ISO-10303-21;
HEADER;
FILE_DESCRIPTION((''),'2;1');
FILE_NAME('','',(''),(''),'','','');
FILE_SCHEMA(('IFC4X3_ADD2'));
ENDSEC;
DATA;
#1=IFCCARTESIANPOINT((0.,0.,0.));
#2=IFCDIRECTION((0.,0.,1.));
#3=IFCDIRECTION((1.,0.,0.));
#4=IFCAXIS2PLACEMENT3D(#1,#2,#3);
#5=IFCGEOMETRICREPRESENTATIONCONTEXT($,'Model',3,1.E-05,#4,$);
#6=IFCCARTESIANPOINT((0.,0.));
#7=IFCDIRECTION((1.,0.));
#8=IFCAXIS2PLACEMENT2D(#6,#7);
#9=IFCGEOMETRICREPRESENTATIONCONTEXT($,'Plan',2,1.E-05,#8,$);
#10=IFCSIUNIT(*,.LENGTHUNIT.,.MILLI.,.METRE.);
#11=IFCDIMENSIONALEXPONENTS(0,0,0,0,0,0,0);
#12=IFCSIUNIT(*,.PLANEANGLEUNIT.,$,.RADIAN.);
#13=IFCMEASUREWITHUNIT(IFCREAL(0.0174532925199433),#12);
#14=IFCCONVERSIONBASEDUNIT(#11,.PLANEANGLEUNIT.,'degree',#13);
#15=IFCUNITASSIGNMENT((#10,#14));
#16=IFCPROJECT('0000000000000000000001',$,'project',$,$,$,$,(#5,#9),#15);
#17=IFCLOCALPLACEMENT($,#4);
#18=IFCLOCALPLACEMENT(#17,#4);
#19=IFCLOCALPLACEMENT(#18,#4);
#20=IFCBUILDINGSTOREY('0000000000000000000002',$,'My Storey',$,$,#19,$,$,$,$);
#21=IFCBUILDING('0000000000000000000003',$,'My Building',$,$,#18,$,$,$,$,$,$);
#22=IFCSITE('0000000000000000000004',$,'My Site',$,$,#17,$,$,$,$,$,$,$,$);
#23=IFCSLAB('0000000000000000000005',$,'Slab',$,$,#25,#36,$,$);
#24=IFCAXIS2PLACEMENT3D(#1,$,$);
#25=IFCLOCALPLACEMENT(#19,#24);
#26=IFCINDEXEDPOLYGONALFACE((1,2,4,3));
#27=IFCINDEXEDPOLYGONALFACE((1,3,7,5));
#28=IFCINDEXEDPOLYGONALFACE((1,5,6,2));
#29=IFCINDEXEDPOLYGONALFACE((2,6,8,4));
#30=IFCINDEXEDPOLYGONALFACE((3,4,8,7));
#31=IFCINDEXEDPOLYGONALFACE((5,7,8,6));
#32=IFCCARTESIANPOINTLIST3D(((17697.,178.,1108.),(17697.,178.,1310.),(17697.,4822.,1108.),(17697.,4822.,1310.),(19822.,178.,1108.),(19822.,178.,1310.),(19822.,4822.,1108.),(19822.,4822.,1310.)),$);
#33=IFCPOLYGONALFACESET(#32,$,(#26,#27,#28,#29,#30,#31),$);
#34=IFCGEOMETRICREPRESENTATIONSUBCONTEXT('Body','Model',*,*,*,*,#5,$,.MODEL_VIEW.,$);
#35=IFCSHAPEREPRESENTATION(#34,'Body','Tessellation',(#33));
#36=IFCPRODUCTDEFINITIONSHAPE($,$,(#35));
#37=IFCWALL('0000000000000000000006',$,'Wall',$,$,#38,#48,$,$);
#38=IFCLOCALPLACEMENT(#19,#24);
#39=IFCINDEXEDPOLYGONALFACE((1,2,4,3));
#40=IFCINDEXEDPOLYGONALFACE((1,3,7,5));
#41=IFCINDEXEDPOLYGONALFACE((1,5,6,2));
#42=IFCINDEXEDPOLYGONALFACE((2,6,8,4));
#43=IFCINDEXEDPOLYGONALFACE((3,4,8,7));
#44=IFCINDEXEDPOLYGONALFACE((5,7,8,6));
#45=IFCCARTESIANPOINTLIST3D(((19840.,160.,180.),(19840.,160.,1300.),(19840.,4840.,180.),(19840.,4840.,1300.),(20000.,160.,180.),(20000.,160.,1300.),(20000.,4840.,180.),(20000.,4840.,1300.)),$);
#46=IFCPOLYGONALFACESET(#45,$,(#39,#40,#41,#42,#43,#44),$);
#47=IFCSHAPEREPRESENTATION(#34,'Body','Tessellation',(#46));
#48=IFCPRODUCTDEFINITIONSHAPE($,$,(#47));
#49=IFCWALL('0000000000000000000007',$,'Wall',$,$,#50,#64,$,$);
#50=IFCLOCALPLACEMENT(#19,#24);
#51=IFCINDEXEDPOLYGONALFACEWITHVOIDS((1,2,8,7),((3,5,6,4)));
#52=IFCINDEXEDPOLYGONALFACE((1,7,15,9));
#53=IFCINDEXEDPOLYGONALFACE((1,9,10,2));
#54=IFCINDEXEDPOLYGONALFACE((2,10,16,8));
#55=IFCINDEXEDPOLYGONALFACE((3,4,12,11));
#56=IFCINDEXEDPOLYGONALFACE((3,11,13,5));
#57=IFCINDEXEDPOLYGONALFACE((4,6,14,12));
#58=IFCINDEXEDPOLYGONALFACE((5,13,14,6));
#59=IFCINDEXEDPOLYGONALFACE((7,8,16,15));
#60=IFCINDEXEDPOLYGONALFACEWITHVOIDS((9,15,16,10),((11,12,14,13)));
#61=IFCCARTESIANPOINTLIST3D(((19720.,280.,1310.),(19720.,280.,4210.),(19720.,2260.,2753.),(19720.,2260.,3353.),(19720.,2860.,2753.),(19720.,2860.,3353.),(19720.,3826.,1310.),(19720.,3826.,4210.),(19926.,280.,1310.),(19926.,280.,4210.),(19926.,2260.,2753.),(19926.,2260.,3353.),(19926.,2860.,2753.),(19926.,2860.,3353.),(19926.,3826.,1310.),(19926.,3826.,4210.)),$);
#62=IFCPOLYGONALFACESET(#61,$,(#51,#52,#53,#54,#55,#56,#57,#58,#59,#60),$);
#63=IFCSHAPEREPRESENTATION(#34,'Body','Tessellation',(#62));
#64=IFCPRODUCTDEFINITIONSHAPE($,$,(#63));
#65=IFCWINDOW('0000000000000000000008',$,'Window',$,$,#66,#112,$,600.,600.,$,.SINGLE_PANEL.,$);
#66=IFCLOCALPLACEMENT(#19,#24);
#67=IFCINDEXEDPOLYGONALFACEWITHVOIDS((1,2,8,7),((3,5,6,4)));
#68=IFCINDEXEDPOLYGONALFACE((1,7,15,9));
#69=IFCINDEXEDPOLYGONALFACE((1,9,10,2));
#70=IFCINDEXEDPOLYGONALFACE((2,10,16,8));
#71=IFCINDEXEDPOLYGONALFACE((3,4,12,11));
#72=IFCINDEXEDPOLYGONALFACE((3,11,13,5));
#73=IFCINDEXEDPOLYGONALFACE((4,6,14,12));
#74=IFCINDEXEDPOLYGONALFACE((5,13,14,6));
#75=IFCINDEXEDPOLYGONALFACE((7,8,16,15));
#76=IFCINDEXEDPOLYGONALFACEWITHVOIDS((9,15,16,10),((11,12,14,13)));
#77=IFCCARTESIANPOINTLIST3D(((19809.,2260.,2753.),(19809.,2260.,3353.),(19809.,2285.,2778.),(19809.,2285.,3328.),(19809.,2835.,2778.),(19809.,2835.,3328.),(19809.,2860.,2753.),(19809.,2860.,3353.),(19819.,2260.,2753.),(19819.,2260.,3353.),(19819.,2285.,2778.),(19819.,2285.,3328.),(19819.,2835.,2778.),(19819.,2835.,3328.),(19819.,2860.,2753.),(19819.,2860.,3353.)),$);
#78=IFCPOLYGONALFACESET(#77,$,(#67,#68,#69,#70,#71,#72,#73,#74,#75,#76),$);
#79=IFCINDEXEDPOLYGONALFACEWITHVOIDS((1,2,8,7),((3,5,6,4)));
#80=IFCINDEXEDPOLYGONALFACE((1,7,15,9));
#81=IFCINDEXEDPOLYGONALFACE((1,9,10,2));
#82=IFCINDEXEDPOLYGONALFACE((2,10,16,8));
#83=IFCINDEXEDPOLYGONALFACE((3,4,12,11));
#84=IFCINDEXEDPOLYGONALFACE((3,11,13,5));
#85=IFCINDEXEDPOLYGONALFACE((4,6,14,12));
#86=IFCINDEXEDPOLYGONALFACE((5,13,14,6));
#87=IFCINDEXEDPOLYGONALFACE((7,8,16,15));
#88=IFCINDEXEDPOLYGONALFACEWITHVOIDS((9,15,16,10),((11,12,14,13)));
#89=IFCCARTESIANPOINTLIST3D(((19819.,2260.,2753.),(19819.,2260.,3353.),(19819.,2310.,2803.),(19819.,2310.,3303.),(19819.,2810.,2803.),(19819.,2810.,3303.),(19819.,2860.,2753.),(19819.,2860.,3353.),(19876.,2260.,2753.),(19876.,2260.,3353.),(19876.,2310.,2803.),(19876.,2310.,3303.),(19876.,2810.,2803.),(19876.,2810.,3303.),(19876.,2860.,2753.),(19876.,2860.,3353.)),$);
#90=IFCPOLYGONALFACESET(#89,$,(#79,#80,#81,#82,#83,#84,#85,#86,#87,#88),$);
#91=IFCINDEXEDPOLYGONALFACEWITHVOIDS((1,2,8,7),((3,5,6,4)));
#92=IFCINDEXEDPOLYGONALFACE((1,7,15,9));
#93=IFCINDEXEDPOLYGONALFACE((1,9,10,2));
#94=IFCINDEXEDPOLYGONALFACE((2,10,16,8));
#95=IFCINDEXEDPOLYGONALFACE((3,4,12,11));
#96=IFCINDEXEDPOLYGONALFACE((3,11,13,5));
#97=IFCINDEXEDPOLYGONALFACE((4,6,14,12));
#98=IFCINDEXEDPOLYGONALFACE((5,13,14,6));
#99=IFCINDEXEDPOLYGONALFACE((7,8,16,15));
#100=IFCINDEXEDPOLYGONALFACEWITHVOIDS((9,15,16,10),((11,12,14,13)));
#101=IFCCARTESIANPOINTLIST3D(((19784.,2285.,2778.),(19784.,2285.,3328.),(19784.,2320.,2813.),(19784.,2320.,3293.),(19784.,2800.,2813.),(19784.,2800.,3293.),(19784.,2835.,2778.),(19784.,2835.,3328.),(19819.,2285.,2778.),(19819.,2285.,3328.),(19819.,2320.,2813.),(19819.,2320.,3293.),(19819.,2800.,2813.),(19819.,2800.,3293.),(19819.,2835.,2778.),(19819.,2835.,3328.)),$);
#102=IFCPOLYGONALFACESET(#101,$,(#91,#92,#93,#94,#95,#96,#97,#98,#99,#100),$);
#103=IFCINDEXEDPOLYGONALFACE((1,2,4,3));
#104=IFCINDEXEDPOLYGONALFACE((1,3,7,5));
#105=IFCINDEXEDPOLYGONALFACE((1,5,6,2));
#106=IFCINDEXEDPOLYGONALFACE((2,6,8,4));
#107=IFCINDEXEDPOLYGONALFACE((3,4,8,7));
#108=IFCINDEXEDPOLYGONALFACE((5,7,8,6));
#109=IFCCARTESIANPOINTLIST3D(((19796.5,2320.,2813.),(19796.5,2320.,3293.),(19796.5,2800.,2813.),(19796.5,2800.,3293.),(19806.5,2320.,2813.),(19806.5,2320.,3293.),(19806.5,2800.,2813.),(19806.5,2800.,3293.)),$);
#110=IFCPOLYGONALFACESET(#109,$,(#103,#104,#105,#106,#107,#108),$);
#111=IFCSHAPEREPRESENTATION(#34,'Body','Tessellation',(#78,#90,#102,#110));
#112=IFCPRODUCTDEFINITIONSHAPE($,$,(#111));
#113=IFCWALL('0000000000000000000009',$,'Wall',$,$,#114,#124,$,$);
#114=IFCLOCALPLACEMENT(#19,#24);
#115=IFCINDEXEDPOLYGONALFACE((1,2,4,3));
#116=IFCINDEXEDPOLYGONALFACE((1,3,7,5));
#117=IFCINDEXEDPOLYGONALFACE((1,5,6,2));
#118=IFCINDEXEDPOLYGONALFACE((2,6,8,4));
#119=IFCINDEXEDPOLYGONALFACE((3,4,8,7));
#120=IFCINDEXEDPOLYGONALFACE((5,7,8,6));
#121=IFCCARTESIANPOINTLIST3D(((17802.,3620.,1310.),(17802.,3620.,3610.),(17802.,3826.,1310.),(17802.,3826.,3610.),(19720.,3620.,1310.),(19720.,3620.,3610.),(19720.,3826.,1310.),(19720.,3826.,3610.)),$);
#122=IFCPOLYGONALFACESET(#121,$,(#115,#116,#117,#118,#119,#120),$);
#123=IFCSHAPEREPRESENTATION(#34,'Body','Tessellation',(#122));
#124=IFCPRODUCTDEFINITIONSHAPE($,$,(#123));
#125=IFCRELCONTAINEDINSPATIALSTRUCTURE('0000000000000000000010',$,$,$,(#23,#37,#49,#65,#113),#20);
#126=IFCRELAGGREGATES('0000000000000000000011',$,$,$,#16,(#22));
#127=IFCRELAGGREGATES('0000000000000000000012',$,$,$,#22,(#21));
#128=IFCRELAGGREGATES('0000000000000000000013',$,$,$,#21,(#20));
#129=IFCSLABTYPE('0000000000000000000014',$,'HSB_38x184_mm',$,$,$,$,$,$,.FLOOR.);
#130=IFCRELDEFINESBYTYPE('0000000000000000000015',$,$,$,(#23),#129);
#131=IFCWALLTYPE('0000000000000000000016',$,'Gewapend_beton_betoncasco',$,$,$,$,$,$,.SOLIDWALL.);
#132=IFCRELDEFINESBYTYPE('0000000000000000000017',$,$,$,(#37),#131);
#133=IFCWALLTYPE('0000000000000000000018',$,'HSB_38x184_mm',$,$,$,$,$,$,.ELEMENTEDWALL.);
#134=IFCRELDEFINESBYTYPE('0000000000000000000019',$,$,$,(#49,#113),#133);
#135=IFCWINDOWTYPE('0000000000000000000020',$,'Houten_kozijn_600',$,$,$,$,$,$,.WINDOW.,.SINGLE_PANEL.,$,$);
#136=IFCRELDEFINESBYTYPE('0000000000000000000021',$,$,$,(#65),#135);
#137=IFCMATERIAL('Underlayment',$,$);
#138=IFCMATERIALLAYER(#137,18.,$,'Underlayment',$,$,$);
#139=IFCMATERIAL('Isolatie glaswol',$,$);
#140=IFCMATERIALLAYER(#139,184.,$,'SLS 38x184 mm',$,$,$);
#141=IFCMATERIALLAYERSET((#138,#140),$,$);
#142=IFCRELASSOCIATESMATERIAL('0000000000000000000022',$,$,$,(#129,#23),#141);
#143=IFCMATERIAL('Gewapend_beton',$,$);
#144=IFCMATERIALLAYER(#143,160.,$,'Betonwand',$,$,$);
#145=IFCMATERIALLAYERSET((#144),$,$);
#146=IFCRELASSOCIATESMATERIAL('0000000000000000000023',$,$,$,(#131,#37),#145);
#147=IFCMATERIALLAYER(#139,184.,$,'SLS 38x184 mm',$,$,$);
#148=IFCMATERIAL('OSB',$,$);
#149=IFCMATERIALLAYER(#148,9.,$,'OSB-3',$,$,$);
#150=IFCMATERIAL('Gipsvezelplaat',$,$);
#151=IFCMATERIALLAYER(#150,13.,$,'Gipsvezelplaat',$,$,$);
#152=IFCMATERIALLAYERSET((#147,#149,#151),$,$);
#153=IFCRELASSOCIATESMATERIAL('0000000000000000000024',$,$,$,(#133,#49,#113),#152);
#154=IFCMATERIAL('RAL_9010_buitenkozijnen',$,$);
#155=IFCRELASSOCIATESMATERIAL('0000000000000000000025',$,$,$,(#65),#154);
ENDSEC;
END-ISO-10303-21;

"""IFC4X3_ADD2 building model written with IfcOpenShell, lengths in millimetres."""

from ifc_helpers import new_model, entity, si_unit, converted_unit, frame, origin_with_axes, origin_2d_with_axis, place, context, subcontext, project, spatial, line, indexed_curve, outline, extrude, shape, source, transform, mapped, material, layer, layer_set, layer_usage, type_object, type_shapes, element, fill, save


model = new_model("IFC4X3_ADD2")

# Units and contexts
model_context = context("Model", 3, precision=1e-05, world=origin_with_axes())
plan_context = context("Plan", 2, precision=1e-05, world=origin_2d_with_axis())
body_context_1 = subcontext(model_context, "Body", "Model", "MODEL_VIEW")
body_context_2 = subcontext(plan_context, "Body", "Plan", "PLAN_VIEW")
ifc_project = project(units=[si_unit("LENGTHUNIT", "METRE", prefix="MILLI"), converted_unit("PLANEANGLEUNIT", "degree", entity("IfcReal", 0.0174532925199433), si_unit("PLANEANGLEUNIT", "RADIAN"), dimensions=[0, 0, 0, 0, 0, 0, 0])], contexts=[model_context, plan_context])

# Site, building, storey
site_placement = place(None, origin_with_axes())
site = spatial("IfcSite", under=ifc_project, at=site_placement, Name="My Site")
building_placement = place(site_placement, origin_with_axes())
building = spatial("IfcBuilding", under=site, at=building_placement, Name="My Building")
storey_placement = place(building_placement, origin_with_axes())
storey = spatial("IfcBuildingStorey", under=building, at=storey_placement, Name="My Storey")

# Slab
ifc_material_1 = material(Name="Underlayment")
ifc_layer_1 = layer(ifc_material_1, 18.0, Name="Underlayment")
ifc_material_2 = material(Name="Isolatie glaswol")
ifc_layer_2 = layer(ifc_material_2, 184.0, Name="SLS 38x184 mm")
ifc_layer_set_1 = layer_set([ifc_layer_1, ifc_layer_2])
ifc_layer_usage_1 = layer_usage(ifc_layer_set_1, "AXIS3", "POSITIVE", 0.0)
slab_type = type_object("IfcSlabType", Name="HSB_38x184_mm", PredefinedType="FLOOR", material=ifc_layer_set_1)
slab_placement = place(storey_placement, frame((17697.0, 178.0, 1108.0), z_axis=(0.0, 0.0, 1.0), x_axis=(1.0, 0.0, 0.0)))
element("IfcSlab", 1, at=slab_placement, inside=storey, type_object=slab_type, material=ifc_layer_usage_1, Name="Slab", context=body_context_1, shape_type="SweptSolid", body=[
    extrude(outline(indexed_curve([(0.0, 0.0), (2125.0, 0.0), (2125.0, 4644.0), (0.0, 4644.0)], segments=[line(3, 2), line(2, 1), line(1, 4), line(4, 3)], self_intersect=False)), None, (0.0, 0.0, 1.0), 202.0),
])

# Wall
ifc_material_3 = material(Name="Gewapend_beton")
ifc_layer_3 = layer(ifc_material_3, 160.0, Name="Betonwand")
ifc_layer_set_2 = layer_set([ifc_layer_3])
ifc_layer_usage_2 = layer_usage(ifc_layer_set_2, "AXIS2", "POSITIVE", 0.0)
wall_type_1 = type_object("IfcWallType", Name="Gewapend_beton_betoncasco", PredefinedType="SOLIDWALL", material=ifc_layer_set_2)
wall_1_placement = place(storey_placement, frame((19840.0, 4840.0, 180.0), z_axis=(0.0, 0.0, 1.0), x_axis=(0.0, -1.0, 0.0)))
element("IfcWall", 2, at=wall_1_placement, inside=storey, type_object=wall_type_1, material=ifc_layer_usage_2, Name="Wall", context=body_context_1, shape_type="SweptSolid", body=[
    extrude(outline(indexed_curve([(0.0, 0.0), (0.0, 160.0), (4680.0, 160.0), (4680.0, 0.0), (0.0, 0.0)], self_intersect=False)), origin_with_axes(), (0.0, 0.0, 1.0), 1120.0),
])

# Wall, opening, window
ifc_layer_4 = layer(ifc_material_2, 184.0, Name="SLS 38x184 mm")
ifc_material_4 = material(Name="OSB")
ifc_layer_5 = layer(ifc_material_4, 9.0, Name="OSB-3")
ifc_material_5 = material(Name="Gipsvezelplaat")
ifc_layer_6 = layer(ifc_material_5, 13.0, Name="Gipsvezelplaat")
ifc_layer_set_3 = layer_set([ifc_layer_4, ifc_layer_5, ifc_layer_6])
ifc_layer_usage_3 = layer_usage(ifc_layer_set_3, "AXIS2", "POSITIVE", 0.0)
wall_type_2 = type_object("IfcWallType", Name="HSB_38x184_mm", PredefinedType="ELEMENTEDWALL", material=ifc_layer_set_3)
wall_2_placement = place(storey_placement, frame((19926.0, 280.0, 1310.0), z_axis=(0.0, 0.0, 1.0), x_axis=(0.0, 1.0, 0.0)))
wall_2 = element("IfcWall", 3, at=wall_2_placement, inside=storey, type_object=wall_type_2, material=ifc_layer_usage_3, Name="Wall", context=body_context_1, shape_type="SweptSolid", body=[
    extrude(outline(indexed_curve([(0.0, 0.0), (0.0, 206.0), (3546.0, 206.0), (3546.0, 0.0), (0.0, 0.0)], self_intersect=False)), origin_with_axes(), (0.0, 0.0, 1.0), 2900.0),
])
shared_shape_1 = source(origin_with_axes(), body_context_1, "Body", "SweptSolid", [
    extrude(outline(indexed_curve([(0.0, 0.0), (600.0, 0.0), (600.0, 600.0), (0.0, 600.0)], segments=[line(1, 2, 3, 4, 1)])), frame((0.0, -600.0, 0.0), z_axis=(0.0, -1.0, 0.0), x_axis=(1.0, 0.0, 0.0)), (0.0, 0.0, -1.0), 1200.0),
])
opening_1_placement = place(wall_2_placement, frame((1980.0, 0.0, 1443.0), z_axis=(0.0, 0.0, 1.0), x_axis=(1.0, 0.0, 0.0)))
opening_1 = element("IfcOpeningElement", 4, at=opening_1_placement, cuts=wall_2, PredefinedType="OPENING", context=body_context_1, shape_type="MappedRepresentation", body=[
    mapped(shared_shape_1, transform((0.0, 0.0, 0.0), x_axis=(1.0, 0.0, 0.0), y_axis=(0.0, 1.0, 0.0), z_axis=(0.0, 0.0, 1.0), scale=1.0)),
])
ifc_material_6 = material(Name="RAL_9010_buitenkozijnen")
window_type = type_object("IfcWindowType", Name="Houten_kozijn_600", PartitioningType="SINGLE_PANEL", PredefinedType="WINDOW")
shared_shape_2 = source(origin_with_axes(), body_context_1, "Body", "SweptSolid", [
    extrude(outline(indexed_curve([(0.0, 0.0), (600.0, 0.0), (600.0, 600.0), (0.0, 600.0)], segments=[line(1, 2, 3, 4, 1)]), holes=[indexed_curve([(25.0, 25.0), (575.0, 25.0), (575.0, 575.0), (25.0, 575.0)], segments=[line(1, 2, 3, 4, 1)])]), frame((0.0, 107.0, 0.0), z_axis=(0.0, -1.0, 0.0), x_axis=(1.0, 0.0, 0.0)), (0.0, 0.0, -1.0), 10.0),
    extrude(outline(indexed_curve([(0.0, 0.0), (600.0, 0.0), (600.0, 600.0), (0.0, 600.0)], segments=[line(1, 2, 3, 4, 1)]), holes=[indexed_curve([(50.0, 50.0), (550.0, 50.0), (550.0, 550.0), (50.0, 550.0)], segments=[line(1, 2, 3, 4, 1)])]), frame((0.0, 50.0, 0.0), z_axis=(0.0, -1.0, 0.0), x_axis=(1.0, 0.0, 0.0)), (0.0, 0.0, -1.0), 57.0),
    extrude(outline(indexed_curve([(0.0, 0.0), (550.0, 0.0), (550.0, 550.0), (0.0, 550.0)], segments=[line(1, 2, 3, 4, 1)]), holes=[indexed_curve([(35.0, 35.0), (515.0, 35.0), (515.0, 515.0), (35.0, 515.0)], segments=[line(1, 2, 3, 4, 1)])]), frame((25.0, 107.0, 25.0), z_axis=(0.0, -1.0, 0.0), x_axis=(1.0, 0.0, 0.0)), (0.0, 0.0, -1.0), 35.0),
    extrude(outline(indexed_curve([(35.0, 35.0), (515.0, 35.0), (515.0, 515.0), (35.0, 515.0)], segments=[line(1, 2, 3, 4, 1)])), frame((25.0, 119.5, 25.0), z_axis=(0.0, -1.0, 0.0), x_axis=(1.0, 0.0, 0.0)), (0.0, 0.0, -1.0), 10.0),
])
shared_shape_3 = source(origin_with_axes(), body_context_2, "Body", "Curve2D", [
    entity("IfcIndexedPolyCurve", entity("IfcCartesianPointList2D", [[50.0, 50.0], [550.0, 50.0]])),
    entity("IfcIndexedPolyCurve", entity("IfcCartesianPointList2D", [[0.0, 117.0], [25.0, 117.0], [25.0, 107.0], [50.0, 107.0], [50.0, 50.0], [0.0, 50.0]]), [entity("IfcLineIndex", [1, 2, 3, 4, 5, 6, 1])]),
    entity("IfcIndexedPolyCurve", entity("IfcCartesianPointList2D", [[600.0, 117.0], [575.0, 117.0], [575.0, 107.0], [550.0, 107.0], [550.0, 50.0], [600.0, 50.0]]), [entity("IfcLineIndex", [1, 2, 3, 4, 5, 6, 1])]),
    entity("IfcIndexedPolyCurve", entity("IfcCartesianPointList2D", [[25.0, 107.0], [60.0, 107.0], [60.0, 142.0], [25.0, 142.0]]), [entity("IfcLineIndex", [1, 2, 3, 4, 1])]),
    entity("IfcIndexedPolyCurve", entity("IfcCartesianPointList2D", [[575.0, 107.0], [540.0, 107.0], [540.0, 142.0], [575.0, 142.0]]), [entity("IfcLineIndex", [1, 2, 3, 4, 1])]),
    entity("IfcIndexedPolyCurve", entity("IfcCartesianPointList2D", [[60.0, 107.0], [540.0, 107.0]])),
    entity("IfcIndexedPolyCurve", entity("IfcCartesianPointList2D", [[60.0, 142.0], [540.0, 142.0]])),
    entity("IfcIndexedPolyCurve", entity("IfcCartesianPointList2D", [[60.0, 124.5], [540.0, 124.5]])),
])
type_shapes(window_type, [shared_shape_2, shared_shape_3])
window_placement = place(opening_1_placement, origin_with_axes())
window = element("IfcWindow", 5, at=window_placement, inside=storey, type_object=window_type, material=ifc_material_6, Name="Window", OverallHeight=600.0, OverallWidth=600.0, PartitioningType="SINGLE_PANEL", shapes=[
    shape(body_context_1, "Body", "MappedRepresentation", [mapped(shared_shape_2, transform((0.0, 0.0, 0.0), x_axis=(1.0, 0.0, 0.0), y_axis=(0.0, 1.0, 0.0), z_axis=(0.0, 0.0, 1.0), scale=1.0))]),
    shape(body_context_2, "Body", "MappedRepresentation", [mapped(shared_shape_3, transform((0.0, 0.0, 0.0), x_axis=(1.0, 0.0, 0.0), y_axis=(0.0, 1.0, 0.0), z_axis=(0.0, 0.0, 1.0), scale=1.0))]),
])
fill(opening_1, window)

# Wall
ifc_layer_usage_4 = layer_usage(ifc_layer_set_3, "AXIS2", "POSITIVE", 0.0)
wall_3_placement = place(storey_placement, frame((17802.0, 3620.0, 1310.0), z_axis=(0.0, 0.0, 1.0), x_axis=(1.0, 0.0, 0.0)))
element("IfcWall", 6, at=wall_3_placement, inside=storey, type_object=wall_type_2, material=ifc_layer_usage_4, Name="Wall", context=body_context_1, shape_type="SweptSolid", body=[
    extrude(outline(indexed_curve([(0.0, 0.0), (0.0, 206.0), (1918.0, 206.0), (1918.0, 0.0), (0.0, 0.0)], self_intersect=False)), origin_with_axes(), (0.0, 0.0, 1.0), 2300.0),
])

save(model, "model.ifc")
